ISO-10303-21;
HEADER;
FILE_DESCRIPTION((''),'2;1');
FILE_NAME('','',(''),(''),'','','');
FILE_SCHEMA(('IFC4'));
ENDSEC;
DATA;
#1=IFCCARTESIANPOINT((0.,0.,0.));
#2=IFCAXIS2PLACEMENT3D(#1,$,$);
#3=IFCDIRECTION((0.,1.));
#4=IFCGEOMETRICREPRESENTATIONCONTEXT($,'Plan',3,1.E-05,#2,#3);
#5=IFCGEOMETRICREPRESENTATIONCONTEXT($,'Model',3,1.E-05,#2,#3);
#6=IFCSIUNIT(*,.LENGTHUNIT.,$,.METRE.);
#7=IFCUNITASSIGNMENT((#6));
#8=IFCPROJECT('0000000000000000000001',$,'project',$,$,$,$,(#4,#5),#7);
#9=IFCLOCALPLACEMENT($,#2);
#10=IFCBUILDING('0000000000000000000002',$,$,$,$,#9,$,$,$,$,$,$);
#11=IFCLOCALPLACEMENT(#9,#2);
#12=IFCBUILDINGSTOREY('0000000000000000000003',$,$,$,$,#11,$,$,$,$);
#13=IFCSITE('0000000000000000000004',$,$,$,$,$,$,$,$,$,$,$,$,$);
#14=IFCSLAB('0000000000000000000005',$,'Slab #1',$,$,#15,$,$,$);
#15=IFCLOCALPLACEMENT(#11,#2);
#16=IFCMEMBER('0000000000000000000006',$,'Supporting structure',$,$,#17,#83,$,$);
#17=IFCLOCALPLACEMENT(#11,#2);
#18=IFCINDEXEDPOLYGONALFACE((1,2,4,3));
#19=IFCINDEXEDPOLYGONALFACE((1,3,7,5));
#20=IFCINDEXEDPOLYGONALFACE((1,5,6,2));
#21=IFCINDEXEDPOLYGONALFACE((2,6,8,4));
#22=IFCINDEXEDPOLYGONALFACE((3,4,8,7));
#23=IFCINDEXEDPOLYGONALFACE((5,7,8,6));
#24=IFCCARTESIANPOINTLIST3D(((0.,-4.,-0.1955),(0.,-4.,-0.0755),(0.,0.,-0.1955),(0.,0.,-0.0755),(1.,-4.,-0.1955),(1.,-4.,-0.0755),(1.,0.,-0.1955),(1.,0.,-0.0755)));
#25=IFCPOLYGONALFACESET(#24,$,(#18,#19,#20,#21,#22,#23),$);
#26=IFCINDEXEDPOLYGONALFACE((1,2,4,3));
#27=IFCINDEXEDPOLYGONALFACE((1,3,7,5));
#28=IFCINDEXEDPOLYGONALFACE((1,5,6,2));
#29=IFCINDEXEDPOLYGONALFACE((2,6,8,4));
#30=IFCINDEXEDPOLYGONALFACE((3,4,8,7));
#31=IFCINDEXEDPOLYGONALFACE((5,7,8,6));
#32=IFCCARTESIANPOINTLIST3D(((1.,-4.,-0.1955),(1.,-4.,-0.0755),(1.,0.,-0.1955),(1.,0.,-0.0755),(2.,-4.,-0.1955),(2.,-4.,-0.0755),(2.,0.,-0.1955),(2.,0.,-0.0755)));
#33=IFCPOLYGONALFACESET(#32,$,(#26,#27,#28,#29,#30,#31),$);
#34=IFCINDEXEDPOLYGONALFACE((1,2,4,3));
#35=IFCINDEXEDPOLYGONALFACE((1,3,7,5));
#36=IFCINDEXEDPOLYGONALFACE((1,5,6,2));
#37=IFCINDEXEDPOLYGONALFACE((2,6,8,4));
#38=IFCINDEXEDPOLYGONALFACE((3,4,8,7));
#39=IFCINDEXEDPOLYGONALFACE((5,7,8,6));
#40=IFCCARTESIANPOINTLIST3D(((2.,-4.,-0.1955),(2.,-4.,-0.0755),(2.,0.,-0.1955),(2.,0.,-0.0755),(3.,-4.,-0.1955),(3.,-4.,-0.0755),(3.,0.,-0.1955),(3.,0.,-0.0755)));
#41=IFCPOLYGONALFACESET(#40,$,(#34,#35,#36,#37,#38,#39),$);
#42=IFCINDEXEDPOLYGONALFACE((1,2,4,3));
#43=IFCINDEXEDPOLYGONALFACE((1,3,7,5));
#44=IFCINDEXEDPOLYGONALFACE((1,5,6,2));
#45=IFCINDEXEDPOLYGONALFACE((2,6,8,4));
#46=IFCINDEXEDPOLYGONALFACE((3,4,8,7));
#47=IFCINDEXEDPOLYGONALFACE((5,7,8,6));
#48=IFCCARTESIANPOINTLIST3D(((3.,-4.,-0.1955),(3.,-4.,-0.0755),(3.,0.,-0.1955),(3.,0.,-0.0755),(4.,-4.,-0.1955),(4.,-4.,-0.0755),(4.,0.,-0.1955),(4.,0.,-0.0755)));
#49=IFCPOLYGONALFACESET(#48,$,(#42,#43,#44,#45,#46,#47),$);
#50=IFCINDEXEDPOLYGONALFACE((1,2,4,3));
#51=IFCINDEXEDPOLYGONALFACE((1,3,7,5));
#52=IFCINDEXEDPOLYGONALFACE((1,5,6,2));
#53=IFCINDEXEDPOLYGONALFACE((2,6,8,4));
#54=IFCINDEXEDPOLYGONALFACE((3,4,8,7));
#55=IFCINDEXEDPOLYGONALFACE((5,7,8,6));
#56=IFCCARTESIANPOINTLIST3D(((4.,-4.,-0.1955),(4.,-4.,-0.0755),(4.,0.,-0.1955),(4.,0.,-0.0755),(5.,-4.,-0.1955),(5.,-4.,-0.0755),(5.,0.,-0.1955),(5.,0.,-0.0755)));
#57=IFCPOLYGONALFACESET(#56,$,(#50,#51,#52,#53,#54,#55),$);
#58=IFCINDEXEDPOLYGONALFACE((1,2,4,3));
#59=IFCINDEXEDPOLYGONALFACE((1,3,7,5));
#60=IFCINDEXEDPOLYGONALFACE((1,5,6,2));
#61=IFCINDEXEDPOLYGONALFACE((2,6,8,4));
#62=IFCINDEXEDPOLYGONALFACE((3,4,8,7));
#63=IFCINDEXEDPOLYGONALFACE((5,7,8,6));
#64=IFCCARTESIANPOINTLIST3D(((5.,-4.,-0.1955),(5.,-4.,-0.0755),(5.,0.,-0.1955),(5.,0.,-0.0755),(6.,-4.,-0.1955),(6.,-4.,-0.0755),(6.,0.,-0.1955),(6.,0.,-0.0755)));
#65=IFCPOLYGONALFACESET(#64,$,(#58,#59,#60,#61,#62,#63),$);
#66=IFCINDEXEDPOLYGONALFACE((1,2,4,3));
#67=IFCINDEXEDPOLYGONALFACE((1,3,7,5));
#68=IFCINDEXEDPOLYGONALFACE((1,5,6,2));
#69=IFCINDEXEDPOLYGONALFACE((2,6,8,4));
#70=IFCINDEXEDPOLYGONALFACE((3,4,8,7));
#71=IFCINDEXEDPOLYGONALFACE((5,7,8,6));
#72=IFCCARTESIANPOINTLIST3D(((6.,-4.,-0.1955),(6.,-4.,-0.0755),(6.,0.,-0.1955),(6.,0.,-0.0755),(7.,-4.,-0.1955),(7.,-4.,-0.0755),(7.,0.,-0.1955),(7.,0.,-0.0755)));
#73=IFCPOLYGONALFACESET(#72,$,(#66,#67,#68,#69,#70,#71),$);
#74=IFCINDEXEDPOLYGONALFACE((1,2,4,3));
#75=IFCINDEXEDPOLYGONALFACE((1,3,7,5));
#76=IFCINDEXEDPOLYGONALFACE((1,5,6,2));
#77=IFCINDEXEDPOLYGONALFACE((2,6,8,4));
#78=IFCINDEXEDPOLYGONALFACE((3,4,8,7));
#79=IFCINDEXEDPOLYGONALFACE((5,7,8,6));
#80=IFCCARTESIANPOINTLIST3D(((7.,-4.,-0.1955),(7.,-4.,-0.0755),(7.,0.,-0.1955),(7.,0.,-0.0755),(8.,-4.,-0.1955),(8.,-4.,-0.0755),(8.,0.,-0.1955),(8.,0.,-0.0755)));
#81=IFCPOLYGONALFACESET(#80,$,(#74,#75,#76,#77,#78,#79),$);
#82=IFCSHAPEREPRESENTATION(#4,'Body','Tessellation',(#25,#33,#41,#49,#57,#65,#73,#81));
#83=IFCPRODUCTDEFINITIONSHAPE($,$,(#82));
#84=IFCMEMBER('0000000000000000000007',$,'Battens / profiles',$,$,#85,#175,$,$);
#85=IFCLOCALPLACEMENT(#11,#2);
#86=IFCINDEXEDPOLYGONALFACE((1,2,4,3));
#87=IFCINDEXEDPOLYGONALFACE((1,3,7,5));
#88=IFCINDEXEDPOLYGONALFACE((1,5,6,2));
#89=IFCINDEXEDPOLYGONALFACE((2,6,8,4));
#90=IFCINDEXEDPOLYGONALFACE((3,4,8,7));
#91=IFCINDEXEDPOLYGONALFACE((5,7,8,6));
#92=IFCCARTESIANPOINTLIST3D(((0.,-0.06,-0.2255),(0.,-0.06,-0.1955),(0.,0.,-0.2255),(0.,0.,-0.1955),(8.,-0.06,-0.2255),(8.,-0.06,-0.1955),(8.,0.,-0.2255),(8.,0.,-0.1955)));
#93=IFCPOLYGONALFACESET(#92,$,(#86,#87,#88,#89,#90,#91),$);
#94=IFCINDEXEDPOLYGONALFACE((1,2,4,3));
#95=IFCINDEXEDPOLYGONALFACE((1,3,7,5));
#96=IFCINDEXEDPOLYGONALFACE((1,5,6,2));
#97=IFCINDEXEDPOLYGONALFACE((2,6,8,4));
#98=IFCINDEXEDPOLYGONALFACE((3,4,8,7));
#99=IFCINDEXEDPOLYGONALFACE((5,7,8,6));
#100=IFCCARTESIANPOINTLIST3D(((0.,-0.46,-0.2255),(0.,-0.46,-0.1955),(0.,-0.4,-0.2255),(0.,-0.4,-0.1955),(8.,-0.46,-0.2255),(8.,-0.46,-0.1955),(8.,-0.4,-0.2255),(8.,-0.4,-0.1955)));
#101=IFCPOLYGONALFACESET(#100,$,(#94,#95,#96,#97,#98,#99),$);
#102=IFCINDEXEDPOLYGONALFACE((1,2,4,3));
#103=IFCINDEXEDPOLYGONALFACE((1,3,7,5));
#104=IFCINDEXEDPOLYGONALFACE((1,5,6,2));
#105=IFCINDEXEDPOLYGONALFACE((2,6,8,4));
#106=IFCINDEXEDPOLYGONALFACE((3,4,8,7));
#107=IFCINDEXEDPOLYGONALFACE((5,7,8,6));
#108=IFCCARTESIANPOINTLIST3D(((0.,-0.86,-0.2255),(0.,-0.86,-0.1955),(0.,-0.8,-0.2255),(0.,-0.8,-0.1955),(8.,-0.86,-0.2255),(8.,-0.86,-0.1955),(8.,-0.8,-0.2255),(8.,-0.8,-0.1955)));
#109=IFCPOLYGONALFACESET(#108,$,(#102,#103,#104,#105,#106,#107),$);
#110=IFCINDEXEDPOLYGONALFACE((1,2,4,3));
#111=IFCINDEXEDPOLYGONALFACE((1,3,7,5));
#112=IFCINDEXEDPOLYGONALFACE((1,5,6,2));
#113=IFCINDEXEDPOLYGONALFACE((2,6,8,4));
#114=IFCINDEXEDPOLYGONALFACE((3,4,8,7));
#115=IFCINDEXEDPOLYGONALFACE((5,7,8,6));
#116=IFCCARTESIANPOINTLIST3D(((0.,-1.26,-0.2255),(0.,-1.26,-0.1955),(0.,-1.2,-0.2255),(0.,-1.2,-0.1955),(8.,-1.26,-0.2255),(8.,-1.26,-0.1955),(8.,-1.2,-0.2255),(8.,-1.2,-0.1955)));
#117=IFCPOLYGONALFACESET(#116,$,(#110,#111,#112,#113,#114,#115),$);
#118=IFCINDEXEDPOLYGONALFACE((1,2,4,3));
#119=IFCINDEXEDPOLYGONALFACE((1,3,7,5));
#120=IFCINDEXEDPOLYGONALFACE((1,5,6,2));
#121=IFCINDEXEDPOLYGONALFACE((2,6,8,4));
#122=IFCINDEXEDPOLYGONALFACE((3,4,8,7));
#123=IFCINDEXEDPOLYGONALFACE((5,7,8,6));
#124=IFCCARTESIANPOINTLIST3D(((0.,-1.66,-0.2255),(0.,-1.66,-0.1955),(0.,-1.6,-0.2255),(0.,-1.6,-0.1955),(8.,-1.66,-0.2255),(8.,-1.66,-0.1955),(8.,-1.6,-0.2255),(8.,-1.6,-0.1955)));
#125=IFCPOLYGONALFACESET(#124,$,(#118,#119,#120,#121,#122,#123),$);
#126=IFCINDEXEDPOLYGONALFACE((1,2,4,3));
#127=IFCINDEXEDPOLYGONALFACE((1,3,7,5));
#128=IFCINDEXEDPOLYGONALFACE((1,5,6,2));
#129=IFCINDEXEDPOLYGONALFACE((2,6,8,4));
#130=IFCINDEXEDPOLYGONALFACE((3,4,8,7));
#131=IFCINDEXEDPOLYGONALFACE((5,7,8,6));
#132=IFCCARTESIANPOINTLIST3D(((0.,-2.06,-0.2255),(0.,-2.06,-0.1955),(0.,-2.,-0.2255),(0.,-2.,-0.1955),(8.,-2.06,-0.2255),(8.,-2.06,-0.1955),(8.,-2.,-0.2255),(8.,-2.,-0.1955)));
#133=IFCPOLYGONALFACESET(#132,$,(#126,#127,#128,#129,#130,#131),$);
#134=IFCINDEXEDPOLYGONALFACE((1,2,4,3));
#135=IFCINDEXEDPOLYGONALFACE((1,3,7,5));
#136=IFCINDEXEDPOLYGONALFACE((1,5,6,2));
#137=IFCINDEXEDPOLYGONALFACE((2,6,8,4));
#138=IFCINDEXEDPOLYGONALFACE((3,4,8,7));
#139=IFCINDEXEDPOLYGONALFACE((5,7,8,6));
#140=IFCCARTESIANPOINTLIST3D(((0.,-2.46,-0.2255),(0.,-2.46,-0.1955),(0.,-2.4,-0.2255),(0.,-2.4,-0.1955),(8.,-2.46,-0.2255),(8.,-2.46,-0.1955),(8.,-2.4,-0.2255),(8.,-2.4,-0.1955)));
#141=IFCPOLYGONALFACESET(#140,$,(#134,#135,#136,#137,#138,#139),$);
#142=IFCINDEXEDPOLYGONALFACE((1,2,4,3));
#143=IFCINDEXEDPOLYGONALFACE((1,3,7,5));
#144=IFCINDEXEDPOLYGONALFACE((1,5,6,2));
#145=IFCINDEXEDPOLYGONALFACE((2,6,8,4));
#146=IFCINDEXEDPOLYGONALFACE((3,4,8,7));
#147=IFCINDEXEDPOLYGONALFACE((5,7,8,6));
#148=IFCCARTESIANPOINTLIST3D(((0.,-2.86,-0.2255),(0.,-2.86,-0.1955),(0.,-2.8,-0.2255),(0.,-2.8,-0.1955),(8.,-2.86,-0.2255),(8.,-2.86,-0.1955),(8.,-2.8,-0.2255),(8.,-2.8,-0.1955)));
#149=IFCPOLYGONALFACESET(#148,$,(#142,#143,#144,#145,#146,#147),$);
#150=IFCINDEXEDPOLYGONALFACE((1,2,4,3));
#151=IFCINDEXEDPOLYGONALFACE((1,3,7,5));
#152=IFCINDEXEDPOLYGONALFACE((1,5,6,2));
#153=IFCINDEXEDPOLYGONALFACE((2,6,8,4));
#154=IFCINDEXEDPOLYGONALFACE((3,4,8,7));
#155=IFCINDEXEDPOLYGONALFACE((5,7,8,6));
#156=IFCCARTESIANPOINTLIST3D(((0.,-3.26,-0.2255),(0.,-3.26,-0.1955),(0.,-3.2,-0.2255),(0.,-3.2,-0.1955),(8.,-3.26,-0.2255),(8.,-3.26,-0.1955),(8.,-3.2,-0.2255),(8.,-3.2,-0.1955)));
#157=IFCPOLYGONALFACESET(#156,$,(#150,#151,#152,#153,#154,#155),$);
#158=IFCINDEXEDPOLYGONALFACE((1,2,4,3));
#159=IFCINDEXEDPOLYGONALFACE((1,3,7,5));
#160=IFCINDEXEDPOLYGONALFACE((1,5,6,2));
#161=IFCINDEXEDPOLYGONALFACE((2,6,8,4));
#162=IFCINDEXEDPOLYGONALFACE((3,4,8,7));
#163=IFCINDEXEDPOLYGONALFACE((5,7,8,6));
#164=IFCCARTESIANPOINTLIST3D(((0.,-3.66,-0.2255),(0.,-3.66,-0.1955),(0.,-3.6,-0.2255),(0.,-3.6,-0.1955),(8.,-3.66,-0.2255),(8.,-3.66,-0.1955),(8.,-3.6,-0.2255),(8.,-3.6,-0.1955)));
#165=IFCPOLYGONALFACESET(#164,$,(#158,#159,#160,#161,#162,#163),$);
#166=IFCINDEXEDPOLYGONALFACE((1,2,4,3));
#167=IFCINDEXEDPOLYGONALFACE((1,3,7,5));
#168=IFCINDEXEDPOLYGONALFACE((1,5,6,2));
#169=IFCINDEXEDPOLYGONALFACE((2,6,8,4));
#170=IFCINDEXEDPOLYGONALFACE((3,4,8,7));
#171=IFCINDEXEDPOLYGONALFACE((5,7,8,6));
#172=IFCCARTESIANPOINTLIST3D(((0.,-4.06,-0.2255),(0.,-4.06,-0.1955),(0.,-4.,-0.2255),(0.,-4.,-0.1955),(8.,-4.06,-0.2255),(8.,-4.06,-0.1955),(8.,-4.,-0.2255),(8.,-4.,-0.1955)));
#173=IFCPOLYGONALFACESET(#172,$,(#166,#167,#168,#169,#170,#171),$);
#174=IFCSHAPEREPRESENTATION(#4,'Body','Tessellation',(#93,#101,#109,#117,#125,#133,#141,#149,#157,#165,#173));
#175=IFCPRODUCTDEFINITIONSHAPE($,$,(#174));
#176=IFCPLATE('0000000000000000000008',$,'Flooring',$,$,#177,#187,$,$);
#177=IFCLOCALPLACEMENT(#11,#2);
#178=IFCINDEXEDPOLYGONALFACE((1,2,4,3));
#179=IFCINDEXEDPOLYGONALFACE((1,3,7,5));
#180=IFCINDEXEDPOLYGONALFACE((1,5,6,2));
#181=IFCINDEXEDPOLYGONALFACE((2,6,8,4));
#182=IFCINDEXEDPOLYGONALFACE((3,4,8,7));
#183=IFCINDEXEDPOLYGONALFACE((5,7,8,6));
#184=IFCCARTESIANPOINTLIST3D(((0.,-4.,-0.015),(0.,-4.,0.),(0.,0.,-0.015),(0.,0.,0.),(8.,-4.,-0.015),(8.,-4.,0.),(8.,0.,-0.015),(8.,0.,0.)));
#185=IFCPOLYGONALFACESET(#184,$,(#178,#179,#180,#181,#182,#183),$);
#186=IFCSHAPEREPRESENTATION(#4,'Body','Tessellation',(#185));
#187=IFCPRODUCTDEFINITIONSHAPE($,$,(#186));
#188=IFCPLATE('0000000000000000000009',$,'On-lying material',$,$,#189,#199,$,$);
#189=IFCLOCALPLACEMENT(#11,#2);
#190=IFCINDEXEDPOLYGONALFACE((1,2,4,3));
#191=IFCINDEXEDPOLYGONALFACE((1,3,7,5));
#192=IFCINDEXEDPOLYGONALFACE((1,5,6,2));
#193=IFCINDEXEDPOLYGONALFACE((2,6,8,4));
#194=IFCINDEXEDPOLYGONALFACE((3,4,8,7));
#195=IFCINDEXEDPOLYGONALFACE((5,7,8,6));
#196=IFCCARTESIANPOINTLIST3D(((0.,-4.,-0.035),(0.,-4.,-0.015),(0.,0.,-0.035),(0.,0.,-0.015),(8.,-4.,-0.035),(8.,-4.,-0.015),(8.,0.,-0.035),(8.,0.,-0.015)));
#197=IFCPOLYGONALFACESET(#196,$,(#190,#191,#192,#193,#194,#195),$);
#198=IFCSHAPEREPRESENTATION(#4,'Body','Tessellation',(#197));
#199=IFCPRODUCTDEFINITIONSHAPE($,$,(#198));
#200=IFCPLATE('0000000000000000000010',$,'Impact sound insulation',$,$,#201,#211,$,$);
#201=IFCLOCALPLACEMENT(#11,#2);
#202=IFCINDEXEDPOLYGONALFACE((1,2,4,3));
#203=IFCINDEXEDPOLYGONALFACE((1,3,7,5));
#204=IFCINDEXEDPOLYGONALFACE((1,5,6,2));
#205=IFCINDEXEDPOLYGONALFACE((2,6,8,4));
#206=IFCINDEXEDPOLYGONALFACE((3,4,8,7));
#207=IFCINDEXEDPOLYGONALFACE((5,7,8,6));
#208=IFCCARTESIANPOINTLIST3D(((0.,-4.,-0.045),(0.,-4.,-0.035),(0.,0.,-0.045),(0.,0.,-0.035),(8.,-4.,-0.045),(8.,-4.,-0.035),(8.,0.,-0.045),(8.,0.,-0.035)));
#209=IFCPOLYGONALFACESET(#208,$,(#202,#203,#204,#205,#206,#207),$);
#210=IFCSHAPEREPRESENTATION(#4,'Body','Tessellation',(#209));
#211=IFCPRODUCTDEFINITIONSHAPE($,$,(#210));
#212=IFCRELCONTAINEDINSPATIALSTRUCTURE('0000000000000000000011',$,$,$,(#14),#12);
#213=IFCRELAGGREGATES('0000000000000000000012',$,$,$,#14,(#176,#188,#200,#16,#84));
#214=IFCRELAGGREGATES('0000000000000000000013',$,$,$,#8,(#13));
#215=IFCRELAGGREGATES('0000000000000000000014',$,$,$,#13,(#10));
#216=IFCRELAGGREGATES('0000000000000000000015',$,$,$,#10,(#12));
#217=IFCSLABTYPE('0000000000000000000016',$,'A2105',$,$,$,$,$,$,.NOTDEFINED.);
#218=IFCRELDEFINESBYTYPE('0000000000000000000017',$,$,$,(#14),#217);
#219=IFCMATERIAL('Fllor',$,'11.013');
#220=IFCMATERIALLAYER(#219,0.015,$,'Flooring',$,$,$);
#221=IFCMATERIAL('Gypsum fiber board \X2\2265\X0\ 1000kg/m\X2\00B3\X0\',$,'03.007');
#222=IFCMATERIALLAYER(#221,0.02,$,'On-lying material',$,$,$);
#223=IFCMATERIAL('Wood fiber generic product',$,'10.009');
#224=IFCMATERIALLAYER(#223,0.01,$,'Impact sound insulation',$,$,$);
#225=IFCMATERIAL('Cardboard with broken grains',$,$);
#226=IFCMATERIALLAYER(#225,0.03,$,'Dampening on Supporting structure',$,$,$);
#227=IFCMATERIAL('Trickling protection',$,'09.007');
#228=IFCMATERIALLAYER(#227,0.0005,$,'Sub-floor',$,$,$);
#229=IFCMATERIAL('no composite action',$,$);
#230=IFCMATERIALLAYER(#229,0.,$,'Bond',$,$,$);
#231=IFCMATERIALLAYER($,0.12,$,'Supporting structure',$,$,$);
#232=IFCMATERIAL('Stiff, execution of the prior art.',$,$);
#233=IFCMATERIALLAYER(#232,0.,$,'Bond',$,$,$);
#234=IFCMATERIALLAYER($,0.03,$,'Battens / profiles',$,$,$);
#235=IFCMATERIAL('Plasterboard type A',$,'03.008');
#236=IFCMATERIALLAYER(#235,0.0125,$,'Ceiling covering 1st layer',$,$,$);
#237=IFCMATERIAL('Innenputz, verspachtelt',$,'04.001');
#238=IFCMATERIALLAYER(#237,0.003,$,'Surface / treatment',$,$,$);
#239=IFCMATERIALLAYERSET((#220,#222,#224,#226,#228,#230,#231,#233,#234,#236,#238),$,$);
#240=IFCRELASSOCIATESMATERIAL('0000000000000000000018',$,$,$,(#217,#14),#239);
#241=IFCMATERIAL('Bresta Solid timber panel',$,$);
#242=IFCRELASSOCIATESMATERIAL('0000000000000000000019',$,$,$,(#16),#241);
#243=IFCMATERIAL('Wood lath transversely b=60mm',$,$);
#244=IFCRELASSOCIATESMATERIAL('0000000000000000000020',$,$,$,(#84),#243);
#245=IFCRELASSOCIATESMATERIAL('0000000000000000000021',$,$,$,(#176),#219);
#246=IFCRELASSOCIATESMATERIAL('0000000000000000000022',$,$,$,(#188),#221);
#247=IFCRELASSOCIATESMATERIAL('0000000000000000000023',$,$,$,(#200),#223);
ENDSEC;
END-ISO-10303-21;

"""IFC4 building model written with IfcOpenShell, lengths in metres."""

from ifc_helpers import new_model, si_unit, direction, frame, frame_2d, origin, origin_with_axes, place, context, project, spatial, rectangle, extrude, material, layer, layer_set, type_object, element, aggregate, save


model = new_model("IFC4")

# Units and contexts
plan_context = context("Plan", 3, precision=1e-05, world=origin(), true_north=direction((0.0, 1.0)))
model_context = context("Model", 3, precision=1e-05, world=origin(), true_north=direction((0.0, 1.0)))
ifc_project = project(units=[si_unit("LENGTHUNIT", "METRE")], contexts=[plan_context, model_context])

# Site, building, storey
site = spatial("IfcSite", under=ifc_project)
building_placement = place(None, origin())
building = spatial("IfcBuilding", under=site, at=building_placement)
storey_placement = place(building_placement, origin())
storey = spatial("IfcBuildingStorey", under=building, at=storey_placement)

# Slab, members, plates
ifc_material_1 = material(Name="Fllor", Category="11.013")
ifc_layer_1 = layer(ifc_material_1, 0.015, Name="Flooring")
ifc_material_2 = material(Name="Gypsum fiber board ≥ 1000kg/m³", Category="03.007")
ifc_layer_2 = layer(ifc_material_2, 0.02, Name="On-lying material")
ifc_material_3 = material(Name="Wood fiber generic product", Category="10.009")
ifc_layer_3 = layer(ifc_material_3, 0.01, Name="Impact sound insulation")
ifc_material_4 = material(Name="Cardboard with broken grains")
ifc_layer_4 = layer(ifc_material_4, 0.03, Name="Dampening on Supporting structure")
ifc_material_5 = material(Name="Trickling protection", Category="09.007")
ifc_layer_5 = layer(ifc_material_5, 0.0005, Name="Sub-floor")
ifc_material_6 = material(Name="no composite action")
ifc_layer_6 = layer(ifc_material_6, 0.0, Name="Bond")
ifc_layer_7 = layer(None, 0.12, Name="Supporting structure")
ifc_material_7 = material(Name="Stiff, execution of the prior art.")
ifc_layer_8 = layer(ifc_material_7, 0.0, Name="Bond")
ifc_layer_9 = layer(None, 0.03, Name="Battens / profiles")
ifc_material_8 = material(Name="Plasterboard type A", Category="03.008")
ifc_layer_10 = layer(ifc_material_8, 0.0125, Name="Ceiling covering 1st layer")
ifc_material_9 = material(Name="Innenputz, verspachtelt", Category="04.001")
ifc_layer_11 = layer(ifc_material_9, 0.003, Name="Surface / treatment")
ifc_layer_set = layer_set([ifc_layer_1, ifc_layer_2, ifc_layer_3, ifc_layer_4, ifc_layer_5, ifc_layer_6, ifc_layer_7, ifc_layer_8, ifc_layer_9, ifc_layer_10, ifc_layer_11])
slab_type = type_object("IfcSlabType", Name="A2105", PredefinedType="NOTDEFINED", material=ifc_layer_set)
slab_placement = place(None, frame((0.0, 0.0, 0.0), z_axis=(0.0, 0.0, -1.0), x_axis=(1.0, 0.0, 0.0)))
slab = element("IfcSlab", 1, at=slab_placement, inside=storey, type_object=slab_type, material=ifc_layer_set, Name="Slab #1")
ifc_material_10 = material(Name="Bresta Solid timber panel")
member_1_placement = place(slab_placement, origin())
member_1 = element("IfcMember", 2, at=member_1_placement, material=ifc_material_10, Name="Supporting structure", context=plan_context, shape_type="SweptSolid", body=[
    extrude(rectangle(XDim=1.0, YDim=0.12, at=frame_2d((0.5, 0.06), x_axis=(1.0, 0.0))), frame((0.0, 4.0, 0.0755), z_axis=(0.0, -1.0, 0.0), x_axis=(1.0, 0.0, 0.0)), (0.0, 0.0, 1.0), 4.0),
    extrude(rectangle(XDim=1.0, YDim=0.12, at=frame_2d((0.5, 0.06), x_axis=(1.0, 0.0))), frame((1.0, 4.0, 0.0755), z_axis=(0.0, -1.0, 0.0), x_axis=(1.0, 0.0, 0.0)), (0.0, 0.0, 1.0), 4.0),
    extrude(rectangle(XDim=1.0, YDim=0.12, at=frame_2d((0.5, 0.06), x_axis=(1.0, 0.0))), frame((2.0, 4.0, 0.0755), z_axis=(0.0, -1.0, 0.0), x_axis=(1.0, 0.0, 0.0)), (0.0, 0.0, 1.0), 4.0),
    extrude(rectangle(XDim=1.0, YDim=0.12, at=frame_2d((0.5, 0.06), x_axis=(1.0, 0.0))), frame((3.0, 4.0, 0.0755), z_axis=(0.0, -1.0, 0.0), x_axis=(1.0, 0.0, 0.0)), (0.0, 0.0, 1.0), 4.0),
    extrude(rectangle(XDim=1.0, YDim=0.12, at=frame_2d((0.5, 0.06), x_axis=(1.0, 0.0))), frame((4.0, 4.0, 0.0755), z_axis=(0.0, -1.0, 0.0), x_axis=(1.0, 0.0, 0.0)), (0.0, 0.0, 1.0), 4.0),
    extrude(rectangle(XDim=1.0, YDim=0.12, at=frame_2d((0.5, 0.06), x_axis=(1.0, 0.0))), frame((5.0, 4.0, 0.0755), z_axis=(0.0, -1.0, 0.0), x_axis=(1.0, 0.0, 0.0)), (0.0, 0.0, 1.0), 4.0),
    extrude(rectangle(XDim=1.0, YDim=0.12, at=frame_2d((0.5, 0.06), x_axis=(1.0, 0.0))), frame((6.0, 4.0, 0.0755), z_axis=(0.0, -1.0, 0.0), x_axis=(1.0, 0.0, 0.0)), (0.0, 0.0, 1.0), 4.0),
    extrude(rectangle(XDim=1.0, YDim=0.12, at=frame_2d((0.5, 0.06), x_axis=(1.0, 0.0))), frame((7.0, 4.0, 0.0755), z_axis=(0.0, -1.0, 0.0), x_axis=(1.0, 0.0, 0.0)), (0.0, 0.0, 1.0), 4.0),
])
ifc_material_11 = material(Name="Wood lath transversely b=60mm")
member_2_placement = place(slab_placement, origin())
member_2 = element("IfcMember", 3, at=member_2_placement, material=ifc_material_11, Name="Battens / profiles", context=plan_context, shape_type="SweptSolid", body=[
    extrude(rectangle(XDim=0.06, YDim=0.03, at=frame_2d((0.03, 0.015), x_axis=(1.0, 0.0))), frame((0.0, 0.0, 0.1955), z_axis=(1.0, 0.0, 0.0), x_axis=(0.0, 1.0, 0.0)), (0.0, 0.0, 1.0), 8.0),
    extrude(rectangle(XDim=0.06, YDim=0.03, at=frame_2d((0.03, 0.015), x_axis=(1.0, 0.0))), frame((0.0, 0.4, 0.1955), z_axis=(1.0, 0.0, 0.0), x_axis=(0.0, 1.0, 0.0)), (0.0, 0.0, 1.0), 8.0),
    extrude(rectangle(XDim=0.06, YDim=0.03, at=frame_2d((0.03, 0.015), x_axis=(1.0, 0.0))), frame((0.0, 0.8, 0.1955), z_axis=(1.0, 0.0, 0.0), x_axis=(0.0, 1.0, 0.0)), (0.0, 0.0, 1.0), 8.0),
    extrude(rectangle(XDim=0.06, YDim=0.03, at=frame_2d((0.03, 0.015), x_axis=(1.0, 0.0))), frame((0.0, 1.2, 0.1955), z_axis=(1.0, 0.0, 0.0), x_axis=(0.0, 1.0, 0.0)), (0.0, 0.0, 1.0), 8.0),
    extrude(rectangle(XDim=0.06, YDim=0.03, at=frame_2d((0.03, 0.015), x_axis=(1.0, 0.0))), frame((0.0, 1.6, 0.1955), z_axis=(1.0, 0.0, 0.0), x_axis=(0.0, 1.0, 0.0)), (0.0, 0.0, 1.0), 8.0),
    extrude(rectangle(XDim=0.06, YDim=0.03, at=frame_2d((0.03, 0.015), x_axis=(1.0, 0.0))), frame((0.0, 2.0, 0.1955), z_axis=(1.0, 0.0, 0.0), x_axis=(0.0, 1.0, 0.0)), (0.0, 0.0, 1.0), 8.0),
    extrude(rectangle(XDim=0.06, YDim=0.03, at=frame_2d((0.03, 0.015), x_axis=(1.0, 0.0))), frame((0.0, 2.4, 0.1955), z_axis=(1.0, 0.0, 0.0), x_axis=(0.0, 1.0, 0.0)), (0.0, 0.0, 1.0), 8.0),
    extrude(rectangle(XDim=0.06, YDim=0.03, at=frame_2d((0.03, 0.015), x_axis=(1.0, 0.0))), frame((0.0, 2.8, 0.1955), z_axis=(1.0, 0.0, 0.0), x_axis=(0.0, 1.0, 0.0)), (0.0, 0.0, 1.0), 8.0),
    extrude(rectangle(XDim=0.06, YDim=0.03, at=frame_2d((0.03, 0.015), x_axis=(1.0, 0.0))), frame((0.0, 3.2, 0.1955), z_axis=(1.0, 0.0, 0.0), x_axis=(0.0, 1.0, 0.0)), (0.0, 0.0, 1.0), 8.0),
    extrude(rectangle(XDim=0.06, YDim=0.03, at=frame_2d((0.03, 0.015), x_axis=(1.0, 0.0))), frame((0.0, 3.6, 0.1955), z_axis=(1.0, 0.0, 0.0), x_axis=(0.0, 1.0, 0.0)), (0.0, 0.0, 1.0), 8.0),
    extrude(rectangle(XDim=0.06, YDim=0.03, at=frame_2d((0.03, 0.015), x_axis=(1.0, 0.0))), frame((0.0, 4.0, 0.1955), z_axis=(1.0, 0.0, 0.0), x_axis=(0.0, 1.0, 0.0)), (0.0, 0.0, 1.0), 8.0),
])
plate_1_placement = place(slab_placement, origin())
plate_1 = element("IfcPlate", 4, at=plate_1_placement, material=ifc_material_1, Name="Flooring", context=plan_context, shape_type="SweptSolid", body=[
    extrude(rectangle(XDim=8.0, YDim=4.0, at=frame_2d((4.0, 2.0), x_axis=(1.0, 0.0))), origin_with_axes(), (0.0, 0.0, 1.0), 0.015),
])
plate_2_placement = place(slab_placement, origin())
plate_2 = element("IfcPlate", 5, at=plate_2_placement, material=ifc_material_2, Name="On-lying material", context=plan_context, shape_type="SweptSolid", body=[
    extrude(rectangle(XDim=8.0, YDim=4.0, at=frame_2d((4.0, 2.0), x_axis=(1.0, 0.0))), frame((0.0, 0.0, 0.015), z_axis=(0.0, 0.0, 1.0), x_axis=(1.0, 0.0, 0.0)), (0.0, 0.0, 1.0), 0.02),
])
plate_3_placement = place(slab_placement, origin())
plate_3 = element("IfcPlate", 6, at=plate_3_placement, material=ifc_material_3, Name="Impact sound insulation", context=plan_context, shape_type="SweptSolid", body=[
    extrude(rectangle(XDim=8.0, YDim=4.0, at=frame_2d((4.0, 2.0), x_axis=(1.0, 0.0))), frame((0.0, 0.0, 0.035), z_axis=(0.0, 0.0, 1.0), x_axis=(1.0, 0.0, 0.0)), (0.0, 0.0, 1.0), 0.01),
])
aggregate(slab, [plate_1, plate_2, plate_3, member_1, member_2])

save(model, "model.ifc")
